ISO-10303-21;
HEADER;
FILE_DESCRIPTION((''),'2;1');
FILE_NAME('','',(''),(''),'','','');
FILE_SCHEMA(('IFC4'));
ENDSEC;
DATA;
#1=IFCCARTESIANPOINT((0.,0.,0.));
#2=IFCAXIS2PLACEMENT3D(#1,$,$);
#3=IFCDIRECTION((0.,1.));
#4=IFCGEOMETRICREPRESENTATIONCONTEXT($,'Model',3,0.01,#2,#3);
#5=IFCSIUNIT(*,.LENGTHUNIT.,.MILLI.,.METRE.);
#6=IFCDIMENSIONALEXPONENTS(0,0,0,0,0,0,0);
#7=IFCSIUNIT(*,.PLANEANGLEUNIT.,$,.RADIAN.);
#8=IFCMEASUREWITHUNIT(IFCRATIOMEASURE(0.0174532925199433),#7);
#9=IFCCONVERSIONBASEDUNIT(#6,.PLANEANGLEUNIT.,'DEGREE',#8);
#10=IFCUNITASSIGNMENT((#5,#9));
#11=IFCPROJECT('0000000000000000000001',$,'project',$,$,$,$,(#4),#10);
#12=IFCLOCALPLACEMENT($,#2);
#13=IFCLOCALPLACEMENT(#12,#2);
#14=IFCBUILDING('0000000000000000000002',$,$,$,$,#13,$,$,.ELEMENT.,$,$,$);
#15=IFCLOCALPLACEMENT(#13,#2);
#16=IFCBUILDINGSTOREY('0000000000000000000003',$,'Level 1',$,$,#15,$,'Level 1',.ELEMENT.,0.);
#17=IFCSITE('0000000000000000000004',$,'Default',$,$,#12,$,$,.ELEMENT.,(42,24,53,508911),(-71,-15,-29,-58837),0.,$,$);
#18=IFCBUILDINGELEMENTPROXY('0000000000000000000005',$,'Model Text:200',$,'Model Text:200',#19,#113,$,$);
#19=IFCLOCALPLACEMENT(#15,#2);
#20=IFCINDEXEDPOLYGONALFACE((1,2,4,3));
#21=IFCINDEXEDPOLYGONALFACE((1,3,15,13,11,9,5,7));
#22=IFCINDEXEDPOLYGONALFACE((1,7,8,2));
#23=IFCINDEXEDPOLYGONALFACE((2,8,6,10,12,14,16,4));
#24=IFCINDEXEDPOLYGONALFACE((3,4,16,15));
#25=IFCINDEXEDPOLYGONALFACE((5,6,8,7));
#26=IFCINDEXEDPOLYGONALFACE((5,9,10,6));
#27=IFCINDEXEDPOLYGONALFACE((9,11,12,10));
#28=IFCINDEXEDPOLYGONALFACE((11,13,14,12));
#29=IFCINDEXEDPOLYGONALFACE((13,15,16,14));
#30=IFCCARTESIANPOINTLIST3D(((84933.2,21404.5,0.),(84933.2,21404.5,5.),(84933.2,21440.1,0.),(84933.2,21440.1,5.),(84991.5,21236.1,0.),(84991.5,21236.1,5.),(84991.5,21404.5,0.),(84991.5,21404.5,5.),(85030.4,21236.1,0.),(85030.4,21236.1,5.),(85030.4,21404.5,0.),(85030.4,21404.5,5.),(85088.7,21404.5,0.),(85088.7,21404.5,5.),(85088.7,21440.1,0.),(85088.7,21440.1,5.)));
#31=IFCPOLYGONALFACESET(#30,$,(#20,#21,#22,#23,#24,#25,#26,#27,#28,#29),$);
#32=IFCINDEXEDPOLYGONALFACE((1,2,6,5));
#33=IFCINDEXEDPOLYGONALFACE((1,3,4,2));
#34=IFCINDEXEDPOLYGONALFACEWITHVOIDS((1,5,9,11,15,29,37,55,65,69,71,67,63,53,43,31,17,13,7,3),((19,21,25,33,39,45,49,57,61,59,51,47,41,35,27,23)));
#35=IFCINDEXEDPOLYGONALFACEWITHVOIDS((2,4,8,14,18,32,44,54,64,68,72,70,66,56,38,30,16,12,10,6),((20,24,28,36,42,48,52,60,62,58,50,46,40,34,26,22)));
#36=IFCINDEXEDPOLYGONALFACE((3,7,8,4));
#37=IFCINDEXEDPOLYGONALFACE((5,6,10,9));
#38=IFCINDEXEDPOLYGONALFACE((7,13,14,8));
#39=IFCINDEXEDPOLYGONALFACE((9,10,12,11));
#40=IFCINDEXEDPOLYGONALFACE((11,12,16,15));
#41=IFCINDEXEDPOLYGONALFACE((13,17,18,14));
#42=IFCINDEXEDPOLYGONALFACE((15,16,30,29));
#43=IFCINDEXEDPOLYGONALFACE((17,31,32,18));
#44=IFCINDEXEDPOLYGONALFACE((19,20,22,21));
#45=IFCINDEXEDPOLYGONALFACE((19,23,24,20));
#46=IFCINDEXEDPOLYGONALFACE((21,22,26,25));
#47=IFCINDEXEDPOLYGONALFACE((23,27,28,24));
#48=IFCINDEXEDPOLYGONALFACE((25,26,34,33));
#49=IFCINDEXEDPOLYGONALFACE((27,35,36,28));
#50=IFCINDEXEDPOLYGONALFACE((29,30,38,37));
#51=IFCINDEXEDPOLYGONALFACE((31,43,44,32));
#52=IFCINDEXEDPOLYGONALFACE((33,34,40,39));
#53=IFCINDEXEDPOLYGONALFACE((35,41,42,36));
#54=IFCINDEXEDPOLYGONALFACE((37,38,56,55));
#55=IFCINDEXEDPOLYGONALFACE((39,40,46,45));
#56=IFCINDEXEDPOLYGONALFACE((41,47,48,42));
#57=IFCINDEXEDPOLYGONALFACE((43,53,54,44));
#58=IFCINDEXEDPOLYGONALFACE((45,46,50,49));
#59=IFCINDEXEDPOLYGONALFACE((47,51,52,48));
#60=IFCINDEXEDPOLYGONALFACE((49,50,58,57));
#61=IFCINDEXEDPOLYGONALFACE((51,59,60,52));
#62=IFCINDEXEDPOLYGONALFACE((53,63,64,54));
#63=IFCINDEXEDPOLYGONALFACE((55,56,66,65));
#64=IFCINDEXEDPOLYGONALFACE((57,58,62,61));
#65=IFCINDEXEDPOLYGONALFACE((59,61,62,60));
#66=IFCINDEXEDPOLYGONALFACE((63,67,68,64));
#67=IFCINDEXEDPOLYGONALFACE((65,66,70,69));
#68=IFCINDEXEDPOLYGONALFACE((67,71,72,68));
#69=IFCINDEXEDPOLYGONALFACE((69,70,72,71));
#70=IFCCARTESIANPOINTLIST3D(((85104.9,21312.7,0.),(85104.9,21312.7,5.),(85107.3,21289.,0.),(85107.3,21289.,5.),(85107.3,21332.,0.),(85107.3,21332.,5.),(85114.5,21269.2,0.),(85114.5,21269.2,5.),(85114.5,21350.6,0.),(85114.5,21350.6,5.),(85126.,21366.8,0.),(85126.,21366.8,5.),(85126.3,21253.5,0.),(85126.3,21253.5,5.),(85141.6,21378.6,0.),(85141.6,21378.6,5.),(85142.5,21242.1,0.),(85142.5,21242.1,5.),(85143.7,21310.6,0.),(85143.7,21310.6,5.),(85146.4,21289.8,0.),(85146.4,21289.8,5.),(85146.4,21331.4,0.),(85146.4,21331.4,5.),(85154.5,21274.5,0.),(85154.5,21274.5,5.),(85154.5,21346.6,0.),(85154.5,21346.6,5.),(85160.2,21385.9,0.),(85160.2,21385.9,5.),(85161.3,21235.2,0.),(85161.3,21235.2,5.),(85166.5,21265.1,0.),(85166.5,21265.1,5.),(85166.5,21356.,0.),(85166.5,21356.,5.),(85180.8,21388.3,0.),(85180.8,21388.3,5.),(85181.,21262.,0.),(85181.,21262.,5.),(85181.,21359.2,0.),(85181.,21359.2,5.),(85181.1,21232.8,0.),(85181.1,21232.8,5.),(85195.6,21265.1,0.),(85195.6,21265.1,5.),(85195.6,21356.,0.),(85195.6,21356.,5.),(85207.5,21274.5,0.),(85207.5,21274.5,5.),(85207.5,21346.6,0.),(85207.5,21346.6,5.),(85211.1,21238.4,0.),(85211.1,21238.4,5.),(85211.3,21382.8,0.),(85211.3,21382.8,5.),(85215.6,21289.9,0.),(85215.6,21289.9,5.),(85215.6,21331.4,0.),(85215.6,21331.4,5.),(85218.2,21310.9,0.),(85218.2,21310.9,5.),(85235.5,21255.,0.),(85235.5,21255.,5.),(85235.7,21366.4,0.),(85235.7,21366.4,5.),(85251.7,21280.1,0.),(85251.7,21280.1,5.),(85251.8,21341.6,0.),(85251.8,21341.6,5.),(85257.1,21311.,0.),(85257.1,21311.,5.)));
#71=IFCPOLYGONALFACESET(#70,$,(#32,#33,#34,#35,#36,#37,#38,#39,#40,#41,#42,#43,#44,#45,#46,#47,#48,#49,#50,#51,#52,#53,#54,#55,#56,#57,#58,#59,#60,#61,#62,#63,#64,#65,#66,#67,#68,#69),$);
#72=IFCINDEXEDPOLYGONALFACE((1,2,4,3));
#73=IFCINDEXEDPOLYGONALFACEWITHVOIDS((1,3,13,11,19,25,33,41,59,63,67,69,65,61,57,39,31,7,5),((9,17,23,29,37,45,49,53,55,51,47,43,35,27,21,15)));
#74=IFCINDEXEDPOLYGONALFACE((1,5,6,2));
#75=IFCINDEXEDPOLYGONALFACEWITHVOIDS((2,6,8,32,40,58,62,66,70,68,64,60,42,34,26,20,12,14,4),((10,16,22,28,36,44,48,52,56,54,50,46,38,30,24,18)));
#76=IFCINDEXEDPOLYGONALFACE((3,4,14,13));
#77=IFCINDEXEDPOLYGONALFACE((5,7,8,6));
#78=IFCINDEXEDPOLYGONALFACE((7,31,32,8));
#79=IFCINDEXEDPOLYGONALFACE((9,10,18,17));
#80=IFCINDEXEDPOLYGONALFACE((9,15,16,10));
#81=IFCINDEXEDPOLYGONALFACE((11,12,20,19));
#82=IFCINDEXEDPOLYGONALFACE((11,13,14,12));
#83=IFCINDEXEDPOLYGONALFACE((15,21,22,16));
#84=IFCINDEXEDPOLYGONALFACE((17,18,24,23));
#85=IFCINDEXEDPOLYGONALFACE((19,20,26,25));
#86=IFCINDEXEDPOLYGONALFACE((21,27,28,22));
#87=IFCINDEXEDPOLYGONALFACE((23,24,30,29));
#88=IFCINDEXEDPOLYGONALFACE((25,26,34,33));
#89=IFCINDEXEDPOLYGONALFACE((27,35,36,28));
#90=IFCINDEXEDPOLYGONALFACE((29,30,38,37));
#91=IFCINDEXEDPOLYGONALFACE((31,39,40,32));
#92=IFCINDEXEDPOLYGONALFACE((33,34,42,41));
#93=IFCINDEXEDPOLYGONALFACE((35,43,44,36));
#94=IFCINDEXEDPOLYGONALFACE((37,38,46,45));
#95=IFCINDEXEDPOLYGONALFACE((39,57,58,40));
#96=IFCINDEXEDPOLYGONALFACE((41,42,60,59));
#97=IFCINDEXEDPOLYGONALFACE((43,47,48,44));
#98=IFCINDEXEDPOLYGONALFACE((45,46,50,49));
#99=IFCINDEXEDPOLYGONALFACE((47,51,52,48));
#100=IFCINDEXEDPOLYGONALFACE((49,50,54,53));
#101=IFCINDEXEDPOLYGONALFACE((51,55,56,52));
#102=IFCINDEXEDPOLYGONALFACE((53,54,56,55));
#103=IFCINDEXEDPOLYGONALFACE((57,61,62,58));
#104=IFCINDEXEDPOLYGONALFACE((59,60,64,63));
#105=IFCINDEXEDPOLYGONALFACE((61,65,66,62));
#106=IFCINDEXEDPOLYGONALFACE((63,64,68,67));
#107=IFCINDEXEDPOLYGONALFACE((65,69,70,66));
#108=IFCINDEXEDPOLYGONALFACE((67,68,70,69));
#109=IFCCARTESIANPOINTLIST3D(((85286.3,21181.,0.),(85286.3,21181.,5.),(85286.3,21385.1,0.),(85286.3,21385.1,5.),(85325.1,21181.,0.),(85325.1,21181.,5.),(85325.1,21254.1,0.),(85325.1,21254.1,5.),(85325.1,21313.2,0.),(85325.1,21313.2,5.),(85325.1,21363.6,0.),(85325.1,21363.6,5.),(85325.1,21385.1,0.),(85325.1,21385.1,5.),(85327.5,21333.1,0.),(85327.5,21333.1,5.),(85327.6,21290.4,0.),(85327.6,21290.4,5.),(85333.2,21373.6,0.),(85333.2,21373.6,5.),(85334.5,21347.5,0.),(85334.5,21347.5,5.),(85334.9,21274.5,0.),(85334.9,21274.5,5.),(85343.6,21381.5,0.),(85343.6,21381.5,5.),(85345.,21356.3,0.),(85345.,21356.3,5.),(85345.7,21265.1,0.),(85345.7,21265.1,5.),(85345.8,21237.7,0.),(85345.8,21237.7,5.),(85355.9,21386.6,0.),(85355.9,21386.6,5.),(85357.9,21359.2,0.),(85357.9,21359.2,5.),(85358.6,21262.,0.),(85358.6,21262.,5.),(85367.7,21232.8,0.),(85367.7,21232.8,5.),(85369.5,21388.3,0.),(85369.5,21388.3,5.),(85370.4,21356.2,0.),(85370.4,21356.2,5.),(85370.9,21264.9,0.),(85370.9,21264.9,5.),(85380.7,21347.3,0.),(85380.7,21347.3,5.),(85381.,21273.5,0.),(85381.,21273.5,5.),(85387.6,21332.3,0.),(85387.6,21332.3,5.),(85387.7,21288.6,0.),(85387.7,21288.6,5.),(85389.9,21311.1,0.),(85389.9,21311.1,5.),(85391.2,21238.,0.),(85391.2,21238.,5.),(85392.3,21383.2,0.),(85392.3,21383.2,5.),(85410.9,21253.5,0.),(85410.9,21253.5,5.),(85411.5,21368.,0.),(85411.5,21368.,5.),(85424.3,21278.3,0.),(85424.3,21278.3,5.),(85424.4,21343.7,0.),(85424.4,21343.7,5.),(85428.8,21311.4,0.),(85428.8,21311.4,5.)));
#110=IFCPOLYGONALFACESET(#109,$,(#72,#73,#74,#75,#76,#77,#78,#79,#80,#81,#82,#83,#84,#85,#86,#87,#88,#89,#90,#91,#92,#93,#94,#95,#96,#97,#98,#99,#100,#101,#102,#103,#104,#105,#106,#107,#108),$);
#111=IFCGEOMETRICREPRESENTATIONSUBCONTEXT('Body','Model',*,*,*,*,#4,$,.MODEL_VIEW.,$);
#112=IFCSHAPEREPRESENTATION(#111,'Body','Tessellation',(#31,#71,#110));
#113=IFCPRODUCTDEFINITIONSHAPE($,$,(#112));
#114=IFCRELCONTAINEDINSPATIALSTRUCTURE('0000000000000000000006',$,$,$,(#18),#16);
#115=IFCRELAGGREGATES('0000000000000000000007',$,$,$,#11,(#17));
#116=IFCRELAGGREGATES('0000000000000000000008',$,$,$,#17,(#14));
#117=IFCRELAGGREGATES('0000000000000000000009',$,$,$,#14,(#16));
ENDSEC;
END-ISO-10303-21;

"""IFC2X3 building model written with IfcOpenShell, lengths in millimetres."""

from ifc_helpers import new_model, entity, si_unit, converted_unit, direction, frame, origin, place, context, subcontext, project, spatial, polyline, outline, extrude, element, save


model = new_model("IFC2X3")

# Units and contexts
model_context = context("Model", 3, precision=0.01, world=origin(), true_north=direction((0.0, 1.0)))
body_context = subcontext(model_context, "Body", "Model", "MODEL_VIEW")
ifc_project = project(units=[si_unit("LENGTHUNIT", "METRE", prefix="MILLI"), converted_unit("PLANEANGLEUNIT", "DEGREE", entity("IfcRatioMeasure", 0.0174532925199433), si_unit("PLANEANGLEUNIT", "RADIAN"), dimensions=[0, 0, 0, 0, 0, 0, 0])], contexts=[model_context])

# Site, building, storey
site_placement = place(None, origin())
site = spatial("IfcSite", under=ifc_project, at=site_placement, Name="Default", CompositionType="ELEMENT", RefLatitude=(42, 24, 53, 508911), RefLongitude=(-71, -15, -29, -58837), RefElevation=0.0)
building_placement = place(site_placement, origin())
building = spatial("IfcBuilding", under=site, at=building_placement, CompositionType="ELEMENT")
storey_placement = place(building_placement, origin())
storey = spatial("IfcBuildingStorey", under=building, at=storey_placement, Name="Level 1", LongName="Level 1", CompositionType="ELEMENT", Elevation=0.0)

# Building element proxy
proxy_1_placement = place(storey_placement, origin())
element("IfcBuildingElementProxy", 1, at=proxy_1_placement, inside=storey, Name="Model Text:200", ObjectType="Model Text:200", context=body_context, shape_type="SweptSolid", body=[
    extrude(outline(polyline([(-19.4, -135.2), (19.4, -135.2), (19.4, 33.2), (77.7, 33.2), (77.7, 68.8), (-77.7, 68.8), (-77.7, 33.2), (-19.4, 33.2), (-19.4, -135.2)])), frame((85010.9, 21371.3, 0.0)), (0.0, 0.0, 1.0), 5.0),
    extrude(outline(polyline([(-8.8, -65.7), (15.1, -65.7), (35.5, -60.5), (52.3, -50.4), (65.3, -35.4), (74.1, -17.3), (78.4, 2.1), (75.9, 32.5), (61.8, 58.5), (38.4, 77.1), (8.3, 85.6), (-22.7, 83.3), (-49.0, 69.9), (-67.8, 47.3), (-76.3, 17.5), (-76.0, -3.3), (-70.7, -22.5), (-60.5, -39.2), (-45.5, -52.3), (-27.7, -61.4), (-8.8, -65.7)]), holes=[polyline([(-2.7, -27.2), (-23.1, -22.5), (-37.5, -12.9), (-45.7, 0.0), (-47.3, 14.8), (-42.7, 28.9), (-32.2, 39.9), (-16.3, 46.3), (4.5, 46.9), (25.1, 42.1), (39.6, 32.6), (47.7, 19.7), (49.4, 5.0), (44.8, -9.2), (34.2, -20.2), (18.2, -26.7), (-2.7, -27.2)])]), frame((85171.1, 21310.6, 0.0), z_axis=(0.0, 0.0, 1.0), x_axis=(0.100608, -0.994926, 0.0)), (0.0, 0.0, 1.0), 5.0),
    extrude(outline(polyline([(-73.1, -75.4), (130.9, -75.4), (130.9, -36.6), (57.8, -36.6), (74.3, -15.9), (79.1, 6.0), (73.9, 29.5), (58.4, 49.2), (33.6, 62.6), (0.5, 67.1), (-31.8, 62.8), (-56.1, 49.8), (-71.3, 30.7), (-76.4, 7.8), (-74.7, -5.8), (-69.6, -18.1), (-61.7, -28.5), (-51.7, -36.6), (-73.1, -36.6), (-73.1, -75.4)]), holes=[polyline([(-1.2, -36.6), (-21.2, -34.2), (-35.6, -27.2), (-44.3, -16.7), (-47.2, -3.8), (-44.3, 8.7), (-35.4, 19.0), (-20.4, 25.9), (0.8, 28.2), (23.3, 26.0), (38.5, 19.3), (47.1, 9.2), (49.9, -3.1), (46.8, -16.0), (37.4, -26.8), (21.5, -34.1), (-1.2, -36.6)])]), frame((85361.7, 21311.9, 0.0), z_axis=(0.0, 0.0, 1.0), x_axis=(0.0, -1.0, 0.0)), (0.0, 0.0, 1.0), 5.0),
])

save(model, "model.ifc")
